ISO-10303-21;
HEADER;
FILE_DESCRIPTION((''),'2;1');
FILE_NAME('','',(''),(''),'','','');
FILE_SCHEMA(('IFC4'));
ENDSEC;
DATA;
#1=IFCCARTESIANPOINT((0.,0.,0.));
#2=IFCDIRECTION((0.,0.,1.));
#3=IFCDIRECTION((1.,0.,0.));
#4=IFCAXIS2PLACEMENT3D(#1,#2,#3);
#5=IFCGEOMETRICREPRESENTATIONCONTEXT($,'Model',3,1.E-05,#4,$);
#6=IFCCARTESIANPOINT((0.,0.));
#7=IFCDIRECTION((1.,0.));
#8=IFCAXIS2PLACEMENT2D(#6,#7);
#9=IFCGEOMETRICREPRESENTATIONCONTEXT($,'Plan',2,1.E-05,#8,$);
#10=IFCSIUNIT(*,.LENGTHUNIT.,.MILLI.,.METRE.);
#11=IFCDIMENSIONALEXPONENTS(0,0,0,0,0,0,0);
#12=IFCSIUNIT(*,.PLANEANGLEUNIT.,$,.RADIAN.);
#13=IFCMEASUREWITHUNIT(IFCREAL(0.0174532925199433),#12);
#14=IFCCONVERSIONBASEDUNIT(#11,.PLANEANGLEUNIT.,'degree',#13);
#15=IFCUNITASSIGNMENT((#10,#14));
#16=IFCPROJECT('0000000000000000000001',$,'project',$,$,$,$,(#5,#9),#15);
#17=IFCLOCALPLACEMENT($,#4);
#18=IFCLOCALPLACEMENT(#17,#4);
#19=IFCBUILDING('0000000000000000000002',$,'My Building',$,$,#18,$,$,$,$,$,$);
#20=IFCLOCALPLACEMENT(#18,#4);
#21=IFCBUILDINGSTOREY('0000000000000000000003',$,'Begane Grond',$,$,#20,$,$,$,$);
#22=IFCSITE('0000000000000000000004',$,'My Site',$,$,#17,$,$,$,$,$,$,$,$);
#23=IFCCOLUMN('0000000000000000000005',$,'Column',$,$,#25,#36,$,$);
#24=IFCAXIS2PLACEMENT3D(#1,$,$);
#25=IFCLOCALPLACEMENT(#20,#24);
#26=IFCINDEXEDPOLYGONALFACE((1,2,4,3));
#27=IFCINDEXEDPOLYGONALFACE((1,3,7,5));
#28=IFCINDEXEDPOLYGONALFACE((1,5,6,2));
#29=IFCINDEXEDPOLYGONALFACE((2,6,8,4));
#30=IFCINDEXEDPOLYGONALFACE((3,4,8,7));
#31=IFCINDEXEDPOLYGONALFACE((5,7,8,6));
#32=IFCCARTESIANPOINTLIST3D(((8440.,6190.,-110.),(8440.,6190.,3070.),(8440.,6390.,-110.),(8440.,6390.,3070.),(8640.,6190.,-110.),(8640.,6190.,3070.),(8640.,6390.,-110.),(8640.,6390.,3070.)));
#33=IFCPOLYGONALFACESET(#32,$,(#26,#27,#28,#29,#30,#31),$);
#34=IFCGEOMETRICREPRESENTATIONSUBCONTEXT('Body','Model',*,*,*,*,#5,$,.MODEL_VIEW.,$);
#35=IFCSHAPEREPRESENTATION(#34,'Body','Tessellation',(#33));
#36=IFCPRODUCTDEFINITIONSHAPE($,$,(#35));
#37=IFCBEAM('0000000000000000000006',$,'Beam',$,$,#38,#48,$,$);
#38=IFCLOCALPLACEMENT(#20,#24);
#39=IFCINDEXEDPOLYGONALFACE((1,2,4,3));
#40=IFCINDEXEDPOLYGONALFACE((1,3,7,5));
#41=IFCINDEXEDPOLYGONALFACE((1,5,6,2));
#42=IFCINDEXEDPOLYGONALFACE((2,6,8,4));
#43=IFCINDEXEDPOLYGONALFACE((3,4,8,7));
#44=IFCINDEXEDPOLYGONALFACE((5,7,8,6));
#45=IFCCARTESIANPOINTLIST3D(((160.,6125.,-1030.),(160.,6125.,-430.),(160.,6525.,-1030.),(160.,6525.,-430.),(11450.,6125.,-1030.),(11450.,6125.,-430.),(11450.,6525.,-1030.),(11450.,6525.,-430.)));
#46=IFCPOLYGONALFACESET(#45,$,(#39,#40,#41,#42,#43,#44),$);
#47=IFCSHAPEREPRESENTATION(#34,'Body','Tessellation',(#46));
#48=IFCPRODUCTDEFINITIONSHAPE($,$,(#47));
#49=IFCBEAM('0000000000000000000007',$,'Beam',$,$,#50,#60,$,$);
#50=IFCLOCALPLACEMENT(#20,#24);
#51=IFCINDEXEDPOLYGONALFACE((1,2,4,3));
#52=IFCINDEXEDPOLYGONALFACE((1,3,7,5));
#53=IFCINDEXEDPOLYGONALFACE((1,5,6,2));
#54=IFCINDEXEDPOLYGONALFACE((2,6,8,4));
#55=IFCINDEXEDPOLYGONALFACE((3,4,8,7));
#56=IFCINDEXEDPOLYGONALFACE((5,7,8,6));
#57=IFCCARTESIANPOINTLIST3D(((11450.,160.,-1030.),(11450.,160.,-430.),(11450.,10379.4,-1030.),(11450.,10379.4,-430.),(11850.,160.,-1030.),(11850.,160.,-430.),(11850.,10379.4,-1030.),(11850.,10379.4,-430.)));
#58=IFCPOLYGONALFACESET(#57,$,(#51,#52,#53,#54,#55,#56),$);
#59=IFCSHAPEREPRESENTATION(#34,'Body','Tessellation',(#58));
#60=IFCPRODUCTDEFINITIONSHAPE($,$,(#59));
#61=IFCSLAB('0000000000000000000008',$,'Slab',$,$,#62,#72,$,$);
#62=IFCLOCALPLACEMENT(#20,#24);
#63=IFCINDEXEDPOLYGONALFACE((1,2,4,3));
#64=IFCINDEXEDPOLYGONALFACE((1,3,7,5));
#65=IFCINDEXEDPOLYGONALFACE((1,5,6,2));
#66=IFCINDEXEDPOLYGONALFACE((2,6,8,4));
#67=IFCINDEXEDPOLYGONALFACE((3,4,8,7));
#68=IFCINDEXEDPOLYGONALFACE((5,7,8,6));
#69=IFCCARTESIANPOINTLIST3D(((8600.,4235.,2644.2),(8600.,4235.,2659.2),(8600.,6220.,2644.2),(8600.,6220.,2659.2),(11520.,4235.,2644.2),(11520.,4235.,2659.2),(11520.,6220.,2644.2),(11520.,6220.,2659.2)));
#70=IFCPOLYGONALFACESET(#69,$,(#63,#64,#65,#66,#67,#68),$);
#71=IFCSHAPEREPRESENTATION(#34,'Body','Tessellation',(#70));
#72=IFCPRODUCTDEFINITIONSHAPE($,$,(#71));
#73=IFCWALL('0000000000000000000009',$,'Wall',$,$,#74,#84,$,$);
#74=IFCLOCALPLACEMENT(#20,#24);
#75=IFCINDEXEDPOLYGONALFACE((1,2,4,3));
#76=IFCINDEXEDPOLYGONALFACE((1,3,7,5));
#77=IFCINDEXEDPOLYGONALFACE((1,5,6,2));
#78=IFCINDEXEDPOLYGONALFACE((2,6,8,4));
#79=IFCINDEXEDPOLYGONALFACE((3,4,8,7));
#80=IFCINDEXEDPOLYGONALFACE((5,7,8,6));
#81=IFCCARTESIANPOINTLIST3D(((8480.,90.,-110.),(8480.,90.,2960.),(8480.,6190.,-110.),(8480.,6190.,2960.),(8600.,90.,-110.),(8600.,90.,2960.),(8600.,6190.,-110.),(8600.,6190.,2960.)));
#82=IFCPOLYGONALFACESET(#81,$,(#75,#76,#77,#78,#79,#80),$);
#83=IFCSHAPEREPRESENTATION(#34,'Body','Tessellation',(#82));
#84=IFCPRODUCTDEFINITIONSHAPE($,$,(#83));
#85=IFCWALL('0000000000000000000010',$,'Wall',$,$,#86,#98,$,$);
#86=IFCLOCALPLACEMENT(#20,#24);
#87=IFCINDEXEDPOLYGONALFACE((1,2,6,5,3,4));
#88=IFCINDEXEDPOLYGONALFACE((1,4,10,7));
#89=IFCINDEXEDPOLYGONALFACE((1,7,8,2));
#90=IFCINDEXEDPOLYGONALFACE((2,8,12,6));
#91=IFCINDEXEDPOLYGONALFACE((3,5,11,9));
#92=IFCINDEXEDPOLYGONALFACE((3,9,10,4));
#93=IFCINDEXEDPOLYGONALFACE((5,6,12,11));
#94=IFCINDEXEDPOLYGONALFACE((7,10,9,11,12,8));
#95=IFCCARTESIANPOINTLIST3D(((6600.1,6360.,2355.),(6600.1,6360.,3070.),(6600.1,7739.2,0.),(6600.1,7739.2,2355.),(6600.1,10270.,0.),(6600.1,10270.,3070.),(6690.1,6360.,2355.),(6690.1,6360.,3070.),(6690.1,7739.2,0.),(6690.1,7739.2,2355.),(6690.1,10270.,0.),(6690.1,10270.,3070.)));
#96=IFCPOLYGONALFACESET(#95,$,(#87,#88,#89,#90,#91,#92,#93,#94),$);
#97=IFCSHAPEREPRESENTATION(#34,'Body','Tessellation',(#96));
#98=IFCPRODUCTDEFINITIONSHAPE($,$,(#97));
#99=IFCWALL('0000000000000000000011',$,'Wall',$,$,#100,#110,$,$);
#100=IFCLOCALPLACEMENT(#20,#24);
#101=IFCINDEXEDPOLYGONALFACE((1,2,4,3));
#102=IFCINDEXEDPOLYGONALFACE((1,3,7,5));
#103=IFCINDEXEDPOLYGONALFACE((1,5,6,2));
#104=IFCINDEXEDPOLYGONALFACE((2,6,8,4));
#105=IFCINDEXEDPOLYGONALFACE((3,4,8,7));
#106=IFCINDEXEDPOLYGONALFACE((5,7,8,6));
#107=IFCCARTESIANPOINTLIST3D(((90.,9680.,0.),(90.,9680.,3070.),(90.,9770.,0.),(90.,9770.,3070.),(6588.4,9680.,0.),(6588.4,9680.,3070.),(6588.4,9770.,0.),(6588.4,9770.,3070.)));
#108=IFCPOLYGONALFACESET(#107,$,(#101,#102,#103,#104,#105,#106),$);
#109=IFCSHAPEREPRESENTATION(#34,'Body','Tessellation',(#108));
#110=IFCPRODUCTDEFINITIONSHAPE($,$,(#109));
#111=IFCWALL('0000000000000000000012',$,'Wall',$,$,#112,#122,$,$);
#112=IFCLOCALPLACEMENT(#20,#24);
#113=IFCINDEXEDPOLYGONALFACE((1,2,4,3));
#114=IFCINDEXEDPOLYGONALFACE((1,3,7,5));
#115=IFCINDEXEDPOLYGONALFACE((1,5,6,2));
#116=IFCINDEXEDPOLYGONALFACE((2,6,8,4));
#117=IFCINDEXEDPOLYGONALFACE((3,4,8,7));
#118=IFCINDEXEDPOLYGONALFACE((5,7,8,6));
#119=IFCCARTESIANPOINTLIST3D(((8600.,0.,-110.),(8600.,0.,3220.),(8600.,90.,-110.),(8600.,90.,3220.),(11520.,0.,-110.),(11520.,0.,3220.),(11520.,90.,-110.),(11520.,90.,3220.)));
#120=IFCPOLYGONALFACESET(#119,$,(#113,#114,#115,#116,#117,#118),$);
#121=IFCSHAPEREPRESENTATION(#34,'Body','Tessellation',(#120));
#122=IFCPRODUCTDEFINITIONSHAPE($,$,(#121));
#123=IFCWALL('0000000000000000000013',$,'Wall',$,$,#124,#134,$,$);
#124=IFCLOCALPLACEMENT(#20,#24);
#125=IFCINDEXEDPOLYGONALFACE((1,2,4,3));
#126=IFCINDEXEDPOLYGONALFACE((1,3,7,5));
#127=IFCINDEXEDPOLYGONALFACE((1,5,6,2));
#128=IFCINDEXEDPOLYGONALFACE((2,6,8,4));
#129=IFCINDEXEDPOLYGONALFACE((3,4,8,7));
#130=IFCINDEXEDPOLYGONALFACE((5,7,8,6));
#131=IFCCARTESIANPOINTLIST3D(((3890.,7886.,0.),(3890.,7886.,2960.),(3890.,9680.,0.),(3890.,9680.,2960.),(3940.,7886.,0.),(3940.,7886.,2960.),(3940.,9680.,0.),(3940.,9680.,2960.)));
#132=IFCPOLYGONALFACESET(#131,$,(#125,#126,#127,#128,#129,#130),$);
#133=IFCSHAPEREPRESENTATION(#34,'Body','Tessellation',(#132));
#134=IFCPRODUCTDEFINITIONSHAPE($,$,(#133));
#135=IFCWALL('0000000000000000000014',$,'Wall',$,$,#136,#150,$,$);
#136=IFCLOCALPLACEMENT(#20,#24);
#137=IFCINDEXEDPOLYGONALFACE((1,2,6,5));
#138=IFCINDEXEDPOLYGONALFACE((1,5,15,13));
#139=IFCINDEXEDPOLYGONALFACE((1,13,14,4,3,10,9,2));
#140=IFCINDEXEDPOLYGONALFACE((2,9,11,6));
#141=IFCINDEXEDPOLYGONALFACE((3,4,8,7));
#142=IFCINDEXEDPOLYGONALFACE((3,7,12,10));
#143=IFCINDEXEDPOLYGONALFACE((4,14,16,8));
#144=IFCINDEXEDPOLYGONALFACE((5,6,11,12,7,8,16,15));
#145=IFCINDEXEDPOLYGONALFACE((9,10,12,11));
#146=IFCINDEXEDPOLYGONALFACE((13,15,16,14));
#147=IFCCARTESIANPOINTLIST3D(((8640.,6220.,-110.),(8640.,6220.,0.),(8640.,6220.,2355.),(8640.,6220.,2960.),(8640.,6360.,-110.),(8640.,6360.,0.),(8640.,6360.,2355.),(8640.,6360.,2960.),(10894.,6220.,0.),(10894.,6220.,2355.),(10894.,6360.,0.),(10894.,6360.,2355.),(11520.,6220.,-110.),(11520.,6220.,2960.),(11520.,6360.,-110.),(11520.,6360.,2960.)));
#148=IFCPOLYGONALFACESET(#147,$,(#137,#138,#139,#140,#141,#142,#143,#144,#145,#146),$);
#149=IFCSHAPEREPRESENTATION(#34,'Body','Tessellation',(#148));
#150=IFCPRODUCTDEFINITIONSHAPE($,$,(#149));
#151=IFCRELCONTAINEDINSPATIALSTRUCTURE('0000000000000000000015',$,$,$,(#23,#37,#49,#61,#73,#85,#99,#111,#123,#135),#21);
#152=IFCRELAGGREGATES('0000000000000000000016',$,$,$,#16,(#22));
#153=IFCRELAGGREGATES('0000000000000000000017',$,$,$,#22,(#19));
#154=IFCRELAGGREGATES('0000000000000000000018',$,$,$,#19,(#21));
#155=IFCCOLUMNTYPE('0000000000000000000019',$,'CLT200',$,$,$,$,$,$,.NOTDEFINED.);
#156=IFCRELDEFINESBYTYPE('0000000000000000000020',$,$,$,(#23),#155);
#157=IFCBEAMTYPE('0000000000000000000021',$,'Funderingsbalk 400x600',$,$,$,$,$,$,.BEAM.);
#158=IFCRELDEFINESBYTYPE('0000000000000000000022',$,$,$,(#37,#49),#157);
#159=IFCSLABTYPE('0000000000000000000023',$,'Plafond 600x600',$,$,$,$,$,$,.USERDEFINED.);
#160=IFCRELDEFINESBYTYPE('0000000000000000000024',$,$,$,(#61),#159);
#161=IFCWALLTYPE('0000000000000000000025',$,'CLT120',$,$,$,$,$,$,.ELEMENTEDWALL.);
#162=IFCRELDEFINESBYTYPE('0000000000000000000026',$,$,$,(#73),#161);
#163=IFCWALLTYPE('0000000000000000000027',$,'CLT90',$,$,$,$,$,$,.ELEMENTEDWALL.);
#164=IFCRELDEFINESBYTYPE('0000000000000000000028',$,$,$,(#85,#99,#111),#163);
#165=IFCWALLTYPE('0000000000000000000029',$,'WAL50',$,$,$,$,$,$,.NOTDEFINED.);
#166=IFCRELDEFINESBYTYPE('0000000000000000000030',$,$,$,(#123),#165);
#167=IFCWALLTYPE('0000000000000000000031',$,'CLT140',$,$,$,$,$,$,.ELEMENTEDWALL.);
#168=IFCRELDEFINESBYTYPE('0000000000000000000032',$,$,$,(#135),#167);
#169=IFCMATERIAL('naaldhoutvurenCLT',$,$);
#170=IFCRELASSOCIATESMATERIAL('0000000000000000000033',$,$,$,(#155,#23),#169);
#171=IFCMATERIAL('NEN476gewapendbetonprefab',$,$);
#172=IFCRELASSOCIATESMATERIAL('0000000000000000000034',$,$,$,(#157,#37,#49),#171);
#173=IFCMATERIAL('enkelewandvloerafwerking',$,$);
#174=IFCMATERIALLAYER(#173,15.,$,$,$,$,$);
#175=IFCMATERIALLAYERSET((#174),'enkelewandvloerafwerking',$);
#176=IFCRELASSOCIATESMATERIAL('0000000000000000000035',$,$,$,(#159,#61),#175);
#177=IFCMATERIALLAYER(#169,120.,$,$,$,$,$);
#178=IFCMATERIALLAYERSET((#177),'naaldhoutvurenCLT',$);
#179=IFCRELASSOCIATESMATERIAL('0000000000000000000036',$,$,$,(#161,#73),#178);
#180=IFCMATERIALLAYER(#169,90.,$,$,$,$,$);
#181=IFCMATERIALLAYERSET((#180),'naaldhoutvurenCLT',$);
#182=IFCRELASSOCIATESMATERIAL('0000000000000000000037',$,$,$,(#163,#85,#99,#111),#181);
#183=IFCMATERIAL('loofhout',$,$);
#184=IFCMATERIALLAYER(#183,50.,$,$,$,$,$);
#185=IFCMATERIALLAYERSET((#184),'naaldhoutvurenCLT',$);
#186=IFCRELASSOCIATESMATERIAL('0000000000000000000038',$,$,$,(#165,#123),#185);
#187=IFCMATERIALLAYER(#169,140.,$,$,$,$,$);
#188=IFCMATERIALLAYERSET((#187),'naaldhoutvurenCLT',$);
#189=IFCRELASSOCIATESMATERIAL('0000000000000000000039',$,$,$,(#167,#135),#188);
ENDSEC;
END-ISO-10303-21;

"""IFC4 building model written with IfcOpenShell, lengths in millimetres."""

from ifc_helpers import new_model, entity, si_unit, converted_unit, frame, origin_with_axes, origin_2d_with_axis, place, context, subcontext, project, spatial, line, indexed_curve, rectangle, outline, extrude, clip, halfspace, source, transform, mapped, material, layer, layer_set, layer_usage, material_profile, profile_set, profile_usage, type_object, element, save


model = new_model("IFC4")

# Units and contexts
model_context = context("Model", 3, precision=1e-05, world=origin_with_axes())
plan_context = context("Plan", 2, precision=1e-05, world=origin_2d_with_axis())
body_context = subcontext(model_context, "Body", "Model", "MODEL_VIEW")
ifc_project = project(units=[si_unit("LENGTHUNIT", "METRE", prefix="MILLI"), converted_unit("PLANEANGLEUNIT", "degree", entity("IfcReal", 0.0174532925199433), si_unit("PLANEANGLEUNIT", "RADIAN"), dimensions=[0, 0, 0, 0, 0, 0, 0])], contexts=[model_context, plan_context])

# Site, building, storey
site_placement = place(None, origin_with_axes())
site = spatial("IfcSite", under=ifc_project, at=site_placement, Name="My Site")
building_placement = place(site_placement, origin_with_axes())
building = spatial("IfcBuilding", under=site, at=building_placement, Name="My Building")
storey_placement = place(building_placement, origin_with_axes())
storey = spatial("IfcBuildingStorey", under=building, at=storey_placement, Name="Begane Grond")

# Column
ifc_material_1 = material(Name="naaldhoutvurenCLT")
ifc_material_profile_1 = material_profile(ifc_material_1, rectangle(XDim=200.0, YDim=200.0))
ifc_profile_set_1 = profile_set([ifc_material_profile_1], Name="naaldhoutvurenCLT")
ifc_profile_usage_1 = profile_usage(ifc_profile_set_1, cardinal=5)
column_type_1 = type_object("IfcColumnType", Name="CLT200", PredefinedType="NOTDEFINED", material=ifc_profile_set_1)
column_1_placement = place(storey_placement, frame((8540.0, 6290.0, -110.0), z_axis=(0.0, 0.0, 1.0), x_axis=(1.0, 0.0, 0.0)))
element("IfcColumn", 1, at=column_1_placement, inside=storey, type_object=column_type_1, material=ifc_profile_usage_1, Name="Column", context=body_context, shape_type="SweptSolid", body=[
    extrude(rectangle(XDim=200.0, YDim=200.0), origin_with_axes(), (0.0, 0.0, 1.0), 3180.0),
])

# Beams
ifc_material_2 = material(Name="NEN476gewapendbetonprefab")
ifc_material_profile_2 = material_profile(ifc_material_2, rectangle(XDim=400.0, YDim=600.0))
ifc_profile_set_2 = profile_set([ifc_material_profile_2], Name="gewapendbetonprefab")
ifc_profile_usage_2 = profile_usage(ifc_profile_set_2, cardinal=5)
beam_type = type_object("IfcBeamType", Name="Funderingsbalk 400x600", PredefinedType="BEAM", material=ifc_profile_set_2)
beam_1_placement = place(storey_placement, frame((11450.0, 6325.0, -730.0), z_axis=(-1.0, 0.0, 0.0), x_axis=(0.0, -1.0, 0.0)))
element("IfcBeam", 2, at=beam_1_placement, inside=storey, type_object=beam_type, material=ifc_profile_usage_2, Name="Beam", context=body_context, shape_type="SweptSolid", body=[
    extrude(rectangle(XDim=400.0, YDim=600.0), origin_with_axes(), (0.0, 0.0, 1.0), 11290.0),
])
ifc_profile_usage_3 = profile_usage(ifc_profile_set_2, cardinal=5)
beam_2_placement = place(storey_placement, frame((11650.0, 160.0, -730.0), z_axis=(0.0, 1.0, 0.0), x_axis=(-1.0, 0.0, 0.0)))
element("IfcBeam", 3, at=beam_2_placement, inside=storey, type_object=beam_type, material=ifc_profile_usage_3, Name="Beam", context=body_context, shape_type="SweptSolid", body=[
    extrude(rectangle(XDim=400.0, YDim=600.0), origin_with_axes(), (0.0, 0.0, 1.0), 10219.4),
])

# Slab
ifc_material_3 = material(Name="enkelewandvloerafwerking")
ifc_layer_1 = layer(ifc_material_3, 15.0)
ifc_layer_set_1 = layer_set([ifc_layer_1], Name="enkelewandvloerafwerking")
slab_type_1 = type_object("IfcSlabType", Name="Plafond 600x600", PredefinedType="USERDEFINED", material=ifc_layer_set_1)
ifc_layer_usage_1 = layer_usage(ifc_layer_set_1, "AXIS3", "POSITIVE", 0.0)
slab_1_placement = place(storey_placement, frame((8600.0, 6220.0, 2644.2), z_axis=(0.0, 0.0, 1.0), x_axis=(1.0, 0.0, 0.0)))
element("IfcSlab", 4, at=slab_1_placement, inside=storey, type_object=slab_type_1, material=ifc_layer_usage_1, Name="Slab", context=body_context, shape_type="SweptSolid", body=[
    extrude(outline(indexed_curve([(0.0, 0.0), (0.0, -1985.0), (2920.0, -1985.0), (2920.0, 0.0)], segments=[line(3, 2), line(2, 1), line(1, 4), line(4, 3)], self_intersect=False)), None, (0.0, 0.0, 1.0), 15.0),
])

# Wall
ifc_layer_2 = layer(ifc_material_1, 120.0)
ifc_layer_set_2 = layer_set([ifc_layer_2], Name="naaldhoutvurenCLT")
ifc_layer_usage_2 = layer_usage(ifc_layer_set_2, "AXIS2", "POSITIVE", 0.0)
wall_type_1 = type_object("IfcWallType", Name="CLT120", PredefinedType="ELEMENTEDWALL", material=ifc_layer_set_2)
wall_1_placement = place(storey_placement, frame((8600.0, 90.0, -110.0), z_axis=(0.0, 0.0, 1.0), x_axis=(0.0, 1.0, 0.0)))
element("IfcWall", 5, at=wall_1_placement, inside=storey, type_object=wall_type_1, material=ifc_layer_usage_2, Name="Wall", context=body_context, shape_type="SweptSolid", body=[
    extrude(outline(indexed_curve([(0.0, 0.0), (0.0, 120.0), (6100.0, 120.0), (6100.0, 0.0), (0.0, 0.0)], self_intersect=False)), origin_with_axes(), (0.0, 0.0, 1.0), 3070.0),
])

# Wall, opening
ifc_layer_3 = layer(ifc_material_1, 90.0)
ifc_layer_set_3 = layer_set([ifc_layer_3], Name="naaldhoutvurenCLT")
wall_type_2 = type_object("IfcWallType", Name="CLT90", PredefinedType="ELEMENTEDWALL", material=ifc_layer_set_3)
ifc_layer_usage_3 = layer_usage(ifc_layer_set_3, "AXIS2", "POSITIVE", 0.0)
wall_2_placement = place(storey_placement, frame((6690.1, 6360.0, 0.0), z_axis=(0.0, 0.0, 1.0), x_axis=(0.0, 1.0, 0.0)))
wall_2 = element("IfcWall", 6, at=wall_2_placement, inside=storey, type_object=wall_type_2, material=ifc_layer_usage_3, Name="Wall", context=body_context, shape_type="SweptSolid", body=[
    extrude(outline(indexed_curve([(0.0, 0.0), (0.0, 90.0), (3910.0, 90.0), (3910.0, 0.0), (0.0, 0.0)], self_intersect=False)), origin_with_axes(), (0.0, 0.0, 1.0), 3070.0),
])
shared_shape_1 = source(origin_with_axes(), body_context, "Body", "SweptSolid", [
    extrude(outline(indexed_curve([(0.0, 0.0), (1379.2, 0.0), (1379.2, 2355.0), (0.0, 2355.0)], segments=[line(1, 2, 3, 4, 1)])), frame((0.0, -600.0, 0.0), z_axis=(0.0, -1.0, 0.0), x_axis=(1.0, 0.0, 0.0)), (0.0, 0.0, -1.0), 1200.0),
])
opening_1_placement = place(wall_2_placement, frame((0.0, -11.0, 0.0), z_axis=(0.0, 0.0, 1.0), x_axis=(1.0, 0.0, 0.0)))
element("IfcOpeningElement", 7, at=opening_1_placement, cuts=wall_2, PredefinedType="OPENING", context=body_context, shape_type="MappedRepresentation", body=[
    mapped(shared_shape_1, transform((0.0, 0.0, 0.0), x_axis=(1.0, 0.0, 0.0), y_axis=(0.0, 1.0, 0.0), z_axis=(0.0, 0.0, 1.0), scale=1.0)),
])

# Walls
ifc_layer_usage_4 = layer_usage(ifc_layer_set_3, "AXIS2", "POSITIVE", 0.0)
wall_3_placement = place(storey_placement, frame((6588.4, 9770.0, 0.0), z_axis=(0.0, 0.0, 1.0), x_axis=(-1.0, 0.0, 0.0)))
element("IfcWall", 8, at=wall_3_placement, inside=storey, type_object=wall_type_2, material=ifc_layer_usage_4, Name="Wall", context=body_context, shape_type="SweptSolid", body=[
    extrude(outline(indexed_curve([(0.0, 0.0), (0.0, 90.0), (6498.4, 90.0), (6498.4, 0.0), (0.0, 0.0)], self_intersect=False)), origin_with_axes(), (0.0, 0.0, 1.0), 3070.0),
])
ifc_layer_usage_5 = layer_usage(ifc_layer_set_3, "AXIS2", "POSITIVE", 0.0)
wall_4_placement = place(storey_placement, frame((8600.0, 0.0, -110.0), z_axis=(0.0, 0.0, 1.0), x_axis=(1.0, 0.0, 0.0)))
element("IfcWall", 9, at=wall_4_placement, inside=storey, type_object=wall_type_2, material=ifc_layer_usage_5, Name="Wall", context=body_context, shape_type="SweptSolid", body=[
    extrude(outline(indexed_curve([(0.0, 0.0), (0.0, 90.0), (2920.0, 90.0), (2920.0, 0.0), (0.0, 0.0)], self_intersect=False)), origin_with_axes(), (0.0, 0.0, 1.0), 3330.0),
])

# Shared definitions
ifc_material_4 = material(Name="loofhout")
ifc_layer_4 = layer(ifc_material_4, 50.0)
ifc_layer_set_4 = layer_set([ifc_layer_4], Name="naaldhoutvurenCLT")
wall_type_3 = type_object("IfcWallType", Name="WAL50", PredefinedType="NOTDEFINED", material=ifc_layer_set_4)

# Wall
ifc_layer_usage_6 = layer_usage(ifc_layer_set_4, "AXIS2", "POSITIVE", 0.0)
wall_5_placement = place(storey_placement, frame((3890.0, 9680.0, 0.0), z_axis=(0.0, 0.0, 1.0), x_axis=(0.0, -1.0, 0.0)))
element("IfcWall", 10, at=wall_5_placement, inside=storey, type_object=wall_type_3, material=ifc_layer_usage_6, Name="Wall", context=body_context, shape_type="Clipping", body=[
    clip(extrude(outline(indexed_curve([(0.0, 0.0), (0.0, 50.0), (1793.9, 50.0), (1793.9, 0.0), (0.0, 0.0)], self_intersect=False)), origin_with_axes(), (0.0, 0.0, 1.0), 2960.0), halfspace(frame((0.0, 0.0, 2960.0), z_axis=(0.0, 0.0, 1.0), x_axis=(-1.0, 0.0, 0.0)), False)),
])

# Wall, opening
ifc_layer_5 = layer(ifc_material_1, 140.0)
ifc_layer_set_5 = layer_set([ifc_layer_5], Name="naaldhoutvurenCLT")
ifc_layer_usage_7 = layer_usage(ifc_layer_set_5, "AXIS2", "POSITIVE", 0.0)
wall_type_4 = type_object("IfcWallType", Name="CLT140", PredefinedType="ELEMENTEDWALL", material=ifc_layer_set_5)
wall_6_placement = place(storey_placement, frame((8640.0, 6220.0, -110.0), z_axis=(0.0, 0.0, 1.0), x_axis=(1.0, -0.000001, 0.0)))
wall_6 = element("IfcWall", 11, at=wall_6_placement, inside=storey, type_object=wall_type_4, material=ifc_layer_usage_7, Name="Wall", context=body_context, shape_type="SweptSolid", body=[
    extrude(outline(indexed_curve([(0.0, 0.0), (0.0, 140.0), (2880.0, 140.0), (2880.0, 0.0), (0.0, 0.0)], self_intersect=False)), origin_with_axes(), (0.0, 0.0, 1.0), 3070.0),
])
shared_shape_2 = source(origin_with_axes(), body_context, "Body", "SweptSolid", [
    extrude(outline(indexed_curve([(0.0, 0.0), (2254.0, 0.0), (2254.0, 2355.0), (0.0, 2355.0)], segments=[line(1, 2, 3, 4, 1)])), frame((0.0, -600.0, 0.0), z_axis=(0.0, -1.0, 0.0), x_axis=(1.0, 0.0, 0.0)), (0.0, 0.0, -1.0), 1200.0),
])
opening_2_placement = place(wall_6_placement, frame((0.0, 43.0, 110.0), z_axis=(0.0, 0.0, 1.0), x_axis=(1.0, 0.0, 0.0)))
element("IfcOpeningElement", 12, at=opening_2_placement, cuts=wall_6, PredefinedType="OPENING", context=body_context, shape_type="MappedRepresentation", body=[
    mapped(shared_shape_2, transform((0.0, 0.0, 0.0), x_axis=(1.0, 0.0, 0.0), y_axis=(0.0, 1.0, 0.0), z_axis=(0.0, 0.0, 1.0), scale=1.0)),
])

save(model, "model.ifc")
